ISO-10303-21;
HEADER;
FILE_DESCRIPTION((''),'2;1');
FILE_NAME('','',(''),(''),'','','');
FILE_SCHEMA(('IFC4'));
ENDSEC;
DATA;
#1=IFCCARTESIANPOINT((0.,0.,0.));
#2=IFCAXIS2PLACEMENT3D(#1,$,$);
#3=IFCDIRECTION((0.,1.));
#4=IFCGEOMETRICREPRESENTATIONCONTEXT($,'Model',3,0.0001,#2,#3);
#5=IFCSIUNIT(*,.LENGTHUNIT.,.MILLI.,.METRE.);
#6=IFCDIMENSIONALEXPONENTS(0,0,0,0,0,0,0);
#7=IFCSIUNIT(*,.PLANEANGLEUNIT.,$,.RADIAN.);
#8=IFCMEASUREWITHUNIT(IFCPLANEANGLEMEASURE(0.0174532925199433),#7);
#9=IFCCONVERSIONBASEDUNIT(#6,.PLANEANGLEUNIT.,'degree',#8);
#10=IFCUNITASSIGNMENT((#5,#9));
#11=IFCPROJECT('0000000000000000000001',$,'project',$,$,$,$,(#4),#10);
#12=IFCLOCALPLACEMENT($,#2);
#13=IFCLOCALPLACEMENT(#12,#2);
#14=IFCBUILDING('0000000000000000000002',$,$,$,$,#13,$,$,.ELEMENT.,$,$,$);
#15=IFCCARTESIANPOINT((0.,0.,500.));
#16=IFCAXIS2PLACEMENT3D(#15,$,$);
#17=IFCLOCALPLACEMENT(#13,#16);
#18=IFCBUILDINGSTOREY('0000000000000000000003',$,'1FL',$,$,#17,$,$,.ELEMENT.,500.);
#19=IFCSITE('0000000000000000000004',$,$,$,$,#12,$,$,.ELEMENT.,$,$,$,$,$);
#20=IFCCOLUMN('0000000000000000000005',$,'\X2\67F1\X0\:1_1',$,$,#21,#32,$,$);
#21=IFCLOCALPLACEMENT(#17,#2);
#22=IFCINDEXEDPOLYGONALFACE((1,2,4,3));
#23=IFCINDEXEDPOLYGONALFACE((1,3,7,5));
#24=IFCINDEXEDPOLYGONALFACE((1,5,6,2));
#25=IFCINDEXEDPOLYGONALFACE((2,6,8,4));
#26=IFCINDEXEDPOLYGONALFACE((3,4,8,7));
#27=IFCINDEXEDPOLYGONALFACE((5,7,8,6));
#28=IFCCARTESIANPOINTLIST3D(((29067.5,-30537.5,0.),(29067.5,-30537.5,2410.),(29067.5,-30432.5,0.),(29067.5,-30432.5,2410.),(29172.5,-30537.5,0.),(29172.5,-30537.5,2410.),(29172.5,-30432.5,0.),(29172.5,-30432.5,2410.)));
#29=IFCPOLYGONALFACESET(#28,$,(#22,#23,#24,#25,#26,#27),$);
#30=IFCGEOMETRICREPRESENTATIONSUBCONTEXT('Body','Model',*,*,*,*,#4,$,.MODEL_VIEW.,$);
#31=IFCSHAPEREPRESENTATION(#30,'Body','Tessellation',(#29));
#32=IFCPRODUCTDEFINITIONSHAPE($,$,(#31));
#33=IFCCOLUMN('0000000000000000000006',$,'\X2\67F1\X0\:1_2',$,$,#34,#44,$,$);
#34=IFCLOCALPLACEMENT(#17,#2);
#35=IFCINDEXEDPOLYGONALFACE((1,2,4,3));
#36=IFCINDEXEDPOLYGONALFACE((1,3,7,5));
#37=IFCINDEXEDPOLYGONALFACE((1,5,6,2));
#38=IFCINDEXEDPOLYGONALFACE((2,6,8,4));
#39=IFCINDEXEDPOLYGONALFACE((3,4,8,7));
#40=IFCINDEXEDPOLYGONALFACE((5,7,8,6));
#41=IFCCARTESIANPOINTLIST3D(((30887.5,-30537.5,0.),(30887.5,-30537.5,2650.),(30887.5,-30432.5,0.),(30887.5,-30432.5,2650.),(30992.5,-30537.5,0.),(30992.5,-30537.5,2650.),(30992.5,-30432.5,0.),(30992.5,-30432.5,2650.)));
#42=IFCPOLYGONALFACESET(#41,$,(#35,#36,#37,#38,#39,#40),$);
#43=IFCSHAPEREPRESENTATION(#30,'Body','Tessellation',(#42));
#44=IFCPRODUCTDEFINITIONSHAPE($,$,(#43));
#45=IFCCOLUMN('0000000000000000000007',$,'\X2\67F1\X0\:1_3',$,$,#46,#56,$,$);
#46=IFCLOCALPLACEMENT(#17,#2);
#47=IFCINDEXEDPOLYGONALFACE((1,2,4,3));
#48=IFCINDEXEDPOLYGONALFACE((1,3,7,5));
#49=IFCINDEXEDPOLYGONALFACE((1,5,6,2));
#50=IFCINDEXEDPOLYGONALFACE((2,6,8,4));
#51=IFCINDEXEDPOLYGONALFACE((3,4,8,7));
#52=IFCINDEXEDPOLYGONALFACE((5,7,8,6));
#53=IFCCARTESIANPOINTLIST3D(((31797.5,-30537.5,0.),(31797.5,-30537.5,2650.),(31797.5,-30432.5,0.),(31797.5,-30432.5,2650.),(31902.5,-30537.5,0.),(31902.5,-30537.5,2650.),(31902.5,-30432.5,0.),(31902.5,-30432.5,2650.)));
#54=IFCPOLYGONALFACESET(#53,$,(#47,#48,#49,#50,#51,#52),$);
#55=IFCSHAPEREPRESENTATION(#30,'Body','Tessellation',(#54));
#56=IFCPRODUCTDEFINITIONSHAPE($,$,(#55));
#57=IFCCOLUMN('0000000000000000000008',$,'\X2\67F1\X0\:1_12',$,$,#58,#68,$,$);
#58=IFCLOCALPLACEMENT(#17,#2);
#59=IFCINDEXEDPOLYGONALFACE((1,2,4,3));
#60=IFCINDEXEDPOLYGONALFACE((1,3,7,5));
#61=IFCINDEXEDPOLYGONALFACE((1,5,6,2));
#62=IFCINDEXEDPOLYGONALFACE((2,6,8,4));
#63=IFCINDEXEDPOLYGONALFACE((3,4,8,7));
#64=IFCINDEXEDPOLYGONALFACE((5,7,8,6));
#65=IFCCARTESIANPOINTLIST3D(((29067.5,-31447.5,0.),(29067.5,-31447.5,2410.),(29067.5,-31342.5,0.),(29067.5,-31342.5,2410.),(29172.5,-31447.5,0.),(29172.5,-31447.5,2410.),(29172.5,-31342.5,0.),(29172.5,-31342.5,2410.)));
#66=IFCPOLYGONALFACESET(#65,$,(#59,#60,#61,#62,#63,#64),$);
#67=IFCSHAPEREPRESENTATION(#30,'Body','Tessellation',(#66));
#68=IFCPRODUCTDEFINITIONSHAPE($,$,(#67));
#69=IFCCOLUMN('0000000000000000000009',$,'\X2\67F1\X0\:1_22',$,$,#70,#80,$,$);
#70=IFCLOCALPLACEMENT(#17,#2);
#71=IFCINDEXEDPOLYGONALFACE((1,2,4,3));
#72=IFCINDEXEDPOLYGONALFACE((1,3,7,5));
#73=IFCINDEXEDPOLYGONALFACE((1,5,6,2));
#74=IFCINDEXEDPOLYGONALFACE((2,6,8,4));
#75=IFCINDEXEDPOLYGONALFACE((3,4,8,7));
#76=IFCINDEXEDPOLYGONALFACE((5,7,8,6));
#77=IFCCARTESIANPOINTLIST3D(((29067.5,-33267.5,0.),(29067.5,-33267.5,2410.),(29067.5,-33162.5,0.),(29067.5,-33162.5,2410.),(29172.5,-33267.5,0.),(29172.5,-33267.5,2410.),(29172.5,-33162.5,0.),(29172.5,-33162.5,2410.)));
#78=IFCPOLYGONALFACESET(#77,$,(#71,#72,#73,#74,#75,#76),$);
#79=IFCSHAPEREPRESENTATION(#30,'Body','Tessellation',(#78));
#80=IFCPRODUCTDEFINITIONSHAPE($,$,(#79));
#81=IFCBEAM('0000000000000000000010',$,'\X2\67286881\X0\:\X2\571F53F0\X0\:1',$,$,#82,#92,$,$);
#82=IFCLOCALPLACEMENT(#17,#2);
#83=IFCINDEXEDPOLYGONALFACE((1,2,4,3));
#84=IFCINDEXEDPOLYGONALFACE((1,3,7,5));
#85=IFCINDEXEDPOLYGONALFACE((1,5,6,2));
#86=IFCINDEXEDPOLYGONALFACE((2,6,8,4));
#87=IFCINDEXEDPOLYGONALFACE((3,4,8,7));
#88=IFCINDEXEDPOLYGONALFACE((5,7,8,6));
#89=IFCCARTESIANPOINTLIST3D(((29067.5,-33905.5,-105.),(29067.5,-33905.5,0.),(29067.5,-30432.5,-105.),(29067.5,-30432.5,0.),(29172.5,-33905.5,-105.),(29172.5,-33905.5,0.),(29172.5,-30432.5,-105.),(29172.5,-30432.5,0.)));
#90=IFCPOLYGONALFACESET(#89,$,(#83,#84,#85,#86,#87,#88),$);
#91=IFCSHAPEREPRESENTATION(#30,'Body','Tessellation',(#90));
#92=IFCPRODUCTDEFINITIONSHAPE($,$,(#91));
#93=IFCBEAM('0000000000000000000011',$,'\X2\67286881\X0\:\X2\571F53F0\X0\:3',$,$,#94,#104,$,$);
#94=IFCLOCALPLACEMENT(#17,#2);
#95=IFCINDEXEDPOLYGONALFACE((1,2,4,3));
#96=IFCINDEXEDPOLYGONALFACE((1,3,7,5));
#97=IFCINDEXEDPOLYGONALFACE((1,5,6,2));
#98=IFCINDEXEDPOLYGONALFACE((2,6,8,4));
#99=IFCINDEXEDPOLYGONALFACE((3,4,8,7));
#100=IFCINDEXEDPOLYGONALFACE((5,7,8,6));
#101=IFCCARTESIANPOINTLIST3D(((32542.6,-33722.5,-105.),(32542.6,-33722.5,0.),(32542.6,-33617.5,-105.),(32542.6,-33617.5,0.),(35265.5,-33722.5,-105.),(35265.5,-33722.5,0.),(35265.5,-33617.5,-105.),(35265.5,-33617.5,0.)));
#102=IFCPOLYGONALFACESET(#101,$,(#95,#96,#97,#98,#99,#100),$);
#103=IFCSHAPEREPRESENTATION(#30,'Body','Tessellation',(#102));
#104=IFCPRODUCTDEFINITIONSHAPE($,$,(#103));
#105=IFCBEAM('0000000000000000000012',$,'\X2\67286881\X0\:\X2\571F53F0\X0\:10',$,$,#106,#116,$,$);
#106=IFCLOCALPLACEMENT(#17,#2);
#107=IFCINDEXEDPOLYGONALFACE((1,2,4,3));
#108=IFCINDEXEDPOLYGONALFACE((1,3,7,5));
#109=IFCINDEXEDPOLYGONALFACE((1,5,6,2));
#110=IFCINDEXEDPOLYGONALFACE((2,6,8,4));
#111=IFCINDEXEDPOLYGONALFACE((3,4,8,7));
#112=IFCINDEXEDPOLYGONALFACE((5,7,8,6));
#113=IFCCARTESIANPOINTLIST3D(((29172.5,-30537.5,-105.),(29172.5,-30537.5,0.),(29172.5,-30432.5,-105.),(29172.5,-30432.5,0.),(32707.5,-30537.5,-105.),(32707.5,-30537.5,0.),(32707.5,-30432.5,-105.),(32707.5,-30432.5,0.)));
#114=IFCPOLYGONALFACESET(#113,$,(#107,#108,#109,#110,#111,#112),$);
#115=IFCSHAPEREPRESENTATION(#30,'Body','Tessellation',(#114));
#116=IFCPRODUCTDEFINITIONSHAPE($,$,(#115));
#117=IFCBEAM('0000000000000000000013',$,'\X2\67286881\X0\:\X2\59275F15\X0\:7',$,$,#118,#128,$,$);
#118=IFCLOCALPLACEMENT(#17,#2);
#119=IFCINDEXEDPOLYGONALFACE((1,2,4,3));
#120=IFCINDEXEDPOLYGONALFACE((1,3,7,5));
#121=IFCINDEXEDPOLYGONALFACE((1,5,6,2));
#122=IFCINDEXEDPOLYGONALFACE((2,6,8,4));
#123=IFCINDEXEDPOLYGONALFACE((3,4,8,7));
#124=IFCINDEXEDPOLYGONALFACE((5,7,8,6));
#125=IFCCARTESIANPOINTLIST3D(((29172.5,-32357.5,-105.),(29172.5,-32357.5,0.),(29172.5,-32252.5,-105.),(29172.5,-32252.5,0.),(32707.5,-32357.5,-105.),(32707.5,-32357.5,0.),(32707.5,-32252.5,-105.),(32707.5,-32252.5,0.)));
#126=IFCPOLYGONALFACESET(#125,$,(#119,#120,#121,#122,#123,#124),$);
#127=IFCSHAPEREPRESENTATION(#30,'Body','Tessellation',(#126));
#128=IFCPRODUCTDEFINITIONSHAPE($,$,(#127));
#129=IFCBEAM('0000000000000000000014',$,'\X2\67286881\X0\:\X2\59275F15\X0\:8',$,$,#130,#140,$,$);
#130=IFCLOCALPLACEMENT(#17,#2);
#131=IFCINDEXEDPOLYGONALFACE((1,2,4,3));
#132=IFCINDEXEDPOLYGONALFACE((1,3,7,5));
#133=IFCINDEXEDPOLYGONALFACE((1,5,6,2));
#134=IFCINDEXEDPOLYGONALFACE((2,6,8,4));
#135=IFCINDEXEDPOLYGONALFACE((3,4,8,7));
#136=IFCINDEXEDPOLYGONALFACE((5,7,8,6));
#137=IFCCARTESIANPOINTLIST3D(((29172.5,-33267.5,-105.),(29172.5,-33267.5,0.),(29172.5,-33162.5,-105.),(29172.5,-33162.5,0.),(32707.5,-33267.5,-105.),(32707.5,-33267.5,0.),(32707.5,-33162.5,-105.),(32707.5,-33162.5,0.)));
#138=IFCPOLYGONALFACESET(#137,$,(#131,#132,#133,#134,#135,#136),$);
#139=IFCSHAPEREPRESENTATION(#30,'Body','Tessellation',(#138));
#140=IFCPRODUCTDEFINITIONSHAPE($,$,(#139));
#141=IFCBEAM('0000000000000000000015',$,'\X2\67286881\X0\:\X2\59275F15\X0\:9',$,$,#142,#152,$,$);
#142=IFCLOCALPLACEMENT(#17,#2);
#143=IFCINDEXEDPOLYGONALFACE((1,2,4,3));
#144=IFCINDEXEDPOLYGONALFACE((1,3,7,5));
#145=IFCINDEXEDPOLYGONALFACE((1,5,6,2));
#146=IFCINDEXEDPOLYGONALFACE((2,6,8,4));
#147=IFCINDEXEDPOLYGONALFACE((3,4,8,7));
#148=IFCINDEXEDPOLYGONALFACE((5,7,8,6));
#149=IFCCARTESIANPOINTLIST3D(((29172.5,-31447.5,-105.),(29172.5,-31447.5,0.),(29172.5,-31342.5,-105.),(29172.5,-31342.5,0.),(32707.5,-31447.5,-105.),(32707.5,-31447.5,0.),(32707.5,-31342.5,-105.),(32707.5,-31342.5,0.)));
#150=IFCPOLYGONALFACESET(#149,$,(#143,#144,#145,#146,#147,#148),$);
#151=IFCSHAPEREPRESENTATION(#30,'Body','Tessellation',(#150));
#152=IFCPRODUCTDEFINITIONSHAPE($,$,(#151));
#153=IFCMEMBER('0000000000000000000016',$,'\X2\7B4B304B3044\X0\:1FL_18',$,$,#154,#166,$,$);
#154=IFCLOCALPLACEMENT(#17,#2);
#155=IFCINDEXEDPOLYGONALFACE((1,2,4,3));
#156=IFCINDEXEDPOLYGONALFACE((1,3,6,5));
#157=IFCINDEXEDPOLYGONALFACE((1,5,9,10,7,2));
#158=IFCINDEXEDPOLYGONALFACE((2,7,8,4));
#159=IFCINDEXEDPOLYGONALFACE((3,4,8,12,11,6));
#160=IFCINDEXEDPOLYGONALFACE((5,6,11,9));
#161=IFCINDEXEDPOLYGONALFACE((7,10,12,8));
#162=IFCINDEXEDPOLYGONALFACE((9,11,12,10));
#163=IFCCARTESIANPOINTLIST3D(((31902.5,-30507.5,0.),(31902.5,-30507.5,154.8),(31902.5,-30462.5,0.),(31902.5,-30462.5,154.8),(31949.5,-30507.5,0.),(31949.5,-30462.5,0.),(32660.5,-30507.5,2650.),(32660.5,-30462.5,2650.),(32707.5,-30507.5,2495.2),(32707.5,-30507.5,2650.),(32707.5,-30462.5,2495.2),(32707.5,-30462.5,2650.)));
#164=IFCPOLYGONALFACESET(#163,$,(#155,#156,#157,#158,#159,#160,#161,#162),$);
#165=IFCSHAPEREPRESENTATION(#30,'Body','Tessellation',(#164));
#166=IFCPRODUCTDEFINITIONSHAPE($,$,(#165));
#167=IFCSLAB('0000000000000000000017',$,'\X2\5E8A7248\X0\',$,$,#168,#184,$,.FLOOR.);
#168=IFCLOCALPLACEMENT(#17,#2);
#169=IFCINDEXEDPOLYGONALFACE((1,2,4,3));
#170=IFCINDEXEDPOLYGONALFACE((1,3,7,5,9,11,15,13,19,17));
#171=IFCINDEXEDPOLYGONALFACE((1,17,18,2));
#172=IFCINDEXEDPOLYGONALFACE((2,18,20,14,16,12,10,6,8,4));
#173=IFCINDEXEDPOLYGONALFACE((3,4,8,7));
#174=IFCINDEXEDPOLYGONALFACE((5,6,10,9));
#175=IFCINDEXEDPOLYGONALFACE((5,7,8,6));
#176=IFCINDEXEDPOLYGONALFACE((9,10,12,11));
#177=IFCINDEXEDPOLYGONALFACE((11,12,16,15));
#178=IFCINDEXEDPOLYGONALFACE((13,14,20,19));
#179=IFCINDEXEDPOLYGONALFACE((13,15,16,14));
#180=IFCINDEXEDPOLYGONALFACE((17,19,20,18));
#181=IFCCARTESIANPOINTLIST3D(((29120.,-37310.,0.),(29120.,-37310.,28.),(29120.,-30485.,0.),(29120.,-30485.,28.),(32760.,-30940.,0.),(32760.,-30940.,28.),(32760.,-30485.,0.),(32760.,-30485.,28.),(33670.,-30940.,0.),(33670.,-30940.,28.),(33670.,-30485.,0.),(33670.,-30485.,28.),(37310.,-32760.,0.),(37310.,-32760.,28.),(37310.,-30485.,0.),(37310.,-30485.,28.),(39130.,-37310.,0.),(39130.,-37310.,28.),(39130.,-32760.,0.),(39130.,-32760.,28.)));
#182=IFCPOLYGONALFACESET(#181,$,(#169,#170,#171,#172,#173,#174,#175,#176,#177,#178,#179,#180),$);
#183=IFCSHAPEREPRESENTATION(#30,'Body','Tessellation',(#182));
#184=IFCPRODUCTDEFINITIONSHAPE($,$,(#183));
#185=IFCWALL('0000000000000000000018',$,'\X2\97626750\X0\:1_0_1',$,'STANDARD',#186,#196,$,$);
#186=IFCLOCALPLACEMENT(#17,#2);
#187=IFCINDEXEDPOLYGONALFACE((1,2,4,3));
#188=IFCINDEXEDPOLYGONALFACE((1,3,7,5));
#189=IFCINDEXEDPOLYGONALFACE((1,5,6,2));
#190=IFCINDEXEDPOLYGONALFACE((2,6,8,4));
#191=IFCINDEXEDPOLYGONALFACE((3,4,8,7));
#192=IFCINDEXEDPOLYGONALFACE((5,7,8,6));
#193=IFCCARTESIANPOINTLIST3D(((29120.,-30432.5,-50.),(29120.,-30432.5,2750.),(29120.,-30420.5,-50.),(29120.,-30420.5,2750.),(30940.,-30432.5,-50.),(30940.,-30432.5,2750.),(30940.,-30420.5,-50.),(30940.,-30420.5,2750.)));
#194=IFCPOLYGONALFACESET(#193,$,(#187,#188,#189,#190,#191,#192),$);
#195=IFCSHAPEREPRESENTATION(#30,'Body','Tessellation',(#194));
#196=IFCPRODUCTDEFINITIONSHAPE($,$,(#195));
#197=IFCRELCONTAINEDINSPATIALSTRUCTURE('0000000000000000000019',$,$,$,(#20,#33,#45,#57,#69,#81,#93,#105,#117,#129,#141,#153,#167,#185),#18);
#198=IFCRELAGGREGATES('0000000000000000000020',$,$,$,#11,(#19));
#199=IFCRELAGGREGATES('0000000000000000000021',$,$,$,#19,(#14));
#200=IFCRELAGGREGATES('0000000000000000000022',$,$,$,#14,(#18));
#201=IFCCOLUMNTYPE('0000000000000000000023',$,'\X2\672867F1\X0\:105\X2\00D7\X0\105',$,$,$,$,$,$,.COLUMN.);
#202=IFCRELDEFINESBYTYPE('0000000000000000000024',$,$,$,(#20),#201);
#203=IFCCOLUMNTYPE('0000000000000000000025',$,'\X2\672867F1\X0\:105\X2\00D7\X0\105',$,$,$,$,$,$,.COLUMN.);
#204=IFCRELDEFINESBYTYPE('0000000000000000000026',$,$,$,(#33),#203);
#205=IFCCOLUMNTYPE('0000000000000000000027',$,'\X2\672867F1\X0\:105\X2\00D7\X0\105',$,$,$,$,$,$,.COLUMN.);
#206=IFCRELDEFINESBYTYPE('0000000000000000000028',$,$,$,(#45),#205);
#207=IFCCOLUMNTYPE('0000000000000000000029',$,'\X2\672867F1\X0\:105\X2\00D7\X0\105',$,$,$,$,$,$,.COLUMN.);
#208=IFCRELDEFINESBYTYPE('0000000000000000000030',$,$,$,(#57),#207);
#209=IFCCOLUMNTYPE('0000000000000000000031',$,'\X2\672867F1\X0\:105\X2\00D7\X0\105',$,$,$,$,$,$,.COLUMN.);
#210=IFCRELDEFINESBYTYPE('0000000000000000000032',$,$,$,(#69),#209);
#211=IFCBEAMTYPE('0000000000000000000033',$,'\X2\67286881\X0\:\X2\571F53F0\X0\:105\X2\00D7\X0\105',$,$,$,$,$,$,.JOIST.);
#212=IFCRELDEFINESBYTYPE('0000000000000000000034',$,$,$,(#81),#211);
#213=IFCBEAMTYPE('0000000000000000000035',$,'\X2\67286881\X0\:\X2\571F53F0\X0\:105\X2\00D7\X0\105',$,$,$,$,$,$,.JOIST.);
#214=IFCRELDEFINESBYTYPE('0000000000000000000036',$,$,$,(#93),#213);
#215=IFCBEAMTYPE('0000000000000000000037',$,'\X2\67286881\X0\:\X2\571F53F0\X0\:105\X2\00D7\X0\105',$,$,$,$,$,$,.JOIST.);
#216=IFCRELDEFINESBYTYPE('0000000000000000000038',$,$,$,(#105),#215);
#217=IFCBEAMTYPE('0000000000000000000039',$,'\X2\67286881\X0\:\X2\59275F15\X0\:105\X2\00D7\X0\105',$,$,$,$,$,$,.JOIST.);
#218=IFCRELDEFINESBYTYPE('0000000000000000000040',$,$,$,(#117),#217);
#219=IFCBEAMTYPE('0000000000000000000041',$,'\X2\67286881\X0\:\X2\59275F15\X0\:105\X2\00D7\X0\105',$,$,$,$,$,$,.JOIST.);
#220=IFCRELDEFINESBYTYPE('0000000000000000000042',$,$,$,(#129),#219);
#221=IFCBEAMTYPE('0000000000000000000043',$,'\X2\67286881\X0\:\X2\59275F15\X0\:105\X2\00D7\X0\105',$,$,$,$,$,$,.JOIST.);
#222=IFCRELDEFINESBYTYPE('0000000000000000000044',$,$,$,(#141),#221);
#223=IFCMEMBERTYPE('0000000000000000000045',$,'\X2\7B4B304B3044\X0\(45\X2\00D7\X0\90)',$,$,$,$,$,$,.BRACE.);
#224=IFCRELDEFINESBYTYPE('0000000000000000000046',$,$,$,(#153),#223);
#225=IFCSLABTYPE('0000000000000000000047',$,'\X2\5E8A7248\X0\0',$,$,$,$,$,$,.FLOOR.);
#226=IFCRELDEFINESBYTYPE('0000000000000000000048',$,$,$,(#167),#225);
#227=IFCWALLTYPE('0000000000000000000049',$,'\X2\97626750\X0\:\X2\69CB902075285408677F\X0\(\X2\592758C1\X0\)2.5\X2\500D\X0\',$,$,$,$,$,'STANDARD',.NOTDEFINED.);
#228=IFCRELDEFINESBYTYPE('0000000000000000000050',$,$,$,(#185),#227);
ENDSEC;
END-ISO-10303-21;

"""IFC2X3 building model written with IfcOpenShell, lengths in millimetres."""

from ifc_helpers import new_model, entity, si_unit, converted_unit, direction, frame, origin, origin_with_axes, origin_2d, place, context, subcontext, project, spatial, polyline, rectangle, outline, extrude, type_object, element, save


model = new_model("IFC2X3")

# Units and contexts
model_context = context("Model", 3, precision=0.0001, world=origin(), true_north=direction((0.0, 1.0)))
body_context = subcontext(model_context, "Body", "Model", "MODEL_VIEW")
ifc_project = project(units=[si_unit("LENGTHUNIT", "METRE", prefix="MILLI"), converted_unit("PLANEANGLEUNIT", "degree", entity("IfcPlaneAngleMeasure", 0.0174532925199433), si_unit("PLANEANGLEUNIT", "RADIAN"), dimensions=[0, 0, 0, 0, 0, 0, 0])], contexts=[model_context])

# Site, building, storey
site_placement = place(None, origin())
site = spatial("IfcSite", under=ifc_project, at=site_placement, CompositionType="ELEMENT")
building_placement = place(site_placement, origin())
building = spatial("IfcBuilding", under=site, at=building_placement, CompositionType="ELEMENT")
storey_placement = place(building_placement, frame((0.0, 0.0, 500.0)))
storey = spatial("IfcBuildingStorey", under=building, at=storey_placement, Name="1FL", CompositionType="ELEMENT", Elevation=500.0)

# Columns
column_type_1 = type_object("IfcColumnType", Name="木柱:105×105", PredefinedType="COLUMN")
column_1_placement = place(storey_placement, frame((29120.0, -30485.0, 0.0)))
element("IfcColumn", 1, at=column_1_placement, inside=storey, type_object=column_type_1, Name="柱:1_1", context=body_context, shape_type="SweptSolid", body=[
    extrude(rectangle(XDim=105.0, YDim=105.0, at=origin_2d()), origin_with_axes(), (0.0, 0.0, 1.0), 2410.0),
])
column_type_2 = type_object("IfcColumnType", Name="木柱:105×105", PredefinedType="COLUMN")
column_2_placement = place(storey_placement, frame((30940.0, -30485.0, 0.0)))
element("IfcColumn", 2, at=column_2_placement, inside=storey, type_object=column_type_2, Name="柱:1_2", context=body_context, shape_type="SweptSolid", body=[
    extrude(rectangle(XDim=105.0, YDim=105.0, at=origin_2d()), origin_with_axes(), (0.0, 0.0, 1.0), 2650.0),
])
column_type_3 = type_object("IfcColumnType", Name="木柱:105×105", PredefinedType="COLUMN")
column_3_placement = place(storey_placement, frame((31850.0, -30485.0, 0.0)))
element("IfcColumn", 3, at=column_3_placement, inside=storey, type_object=column_type_3, Name="柱:1_3", context=body_context, shape_type="SweptSolid", body=[
    extrude(rectangle(XDim=105.0, YDim=105.0, at=origin_2d()), origin_with_axes(), (0.0, 0.0, 1.0), 2650.0),
])
column_type_4 = type_object("IfcColumnType", Name="木柱:105×105", PredefinedType="COLUMN")
column_4_placement = place(storey_placement, frame((29120.0, -31395.0, 0.0)))
element("IfcColumn", 4, at=column_4_placement, inside=storey, type_object=column_type_4, Name="柱:1_12", context=body_context, shape_type="SweptSolid", body=[
    extrude(rectangle(XDim=105.0, YDim=105.0, at=origin_2d()), origin_with_axes(), (0.0, 0.0, 1.0), 2410.0),
])
column_type_5 = type_object("IfcColumnType", Name="木柱:105×105", PredefinedType="COLUMN")
column_5_placement = place(storey_placement, frame((29120.0, -33215.0, 0.0)))
element("IfcColumn", 5, at=column_5_placement, inside=storey, type_object=column_type_5, Name="柱:1_22", context=body_context, shape_type="SweptSolid", body=[
    extrude(rectangle(XDim=105.0, YDim=105.0, at=origin_2d()), origin_with_axes(), (0.0, 0.0, 1.0), 2410.0),
])

# Beams
beam_type_1 = type_object("IfcBeamType", Name="木梁:土台:105×105", PredefinedType="JOIST")
beam_1_placement = place(storey_placement, frame((29120.0, -30432.5, -52.5), z_axis=(0.0, -1.0, 0.0), x_axis=(1.0, 0.0, 0.0)))
element("IfcBeam", 6, at=beam_1_placement, inside=storey, type_object=beam_type_1, Name="木梁:土台:1", context=body_context, shape_type="SweptSolid", body=[
    extrude(rectangle(XDim=105.0, YDim=105.0, at=origin_2d()), origin_with_axes(), (0.0, 0.0, 1.0), 3473.0),
])
beam_type_2 = type_object("IfcBeamType", Name="木梁:土台:105×105", PredefinedType="JOIST")
beam_2_placement = place(storey_placement, frame((32542.6, -33670.0, -52.5), z_axis=(1.0, 0.0, 0.0), x_axis=(0.0, 1.0, 0.0)))
element("IfcBeam", 7, at=beam_2_placement, inside=storey, type_object=beam_type_2, Name="木梁:土台:3", context=body_context, shape_type="SweptSolid", body=[
    extrude(rectangle(XDim=105.0, YDim=105.0, at=origin_2d()), origin_with_axes(), (0.0, 0.0, 1.0), 2722.9),
])
beam_type_3 = type_object("IfcBeamType", Name="木梁:土台:105×105", PredefinedType="JOIST")
beam_3_placement = place(storey_placement, frame((29172.5, -30485.0, -52.5), z_axis=(1.0, 0.0, 0.0), x_axis=(0.0, 1.0, 0.0)))
element("IfcBeam", 8, at=beam_3_placement, inside=storey, type_object=beam_type_3, Name="木梁:土台:10", context=body_context, shape_type="SweptSolid", body=[
    extrude(rectangle(XDim=105.0, YDim=105.0, at=origin_2d()), origin_with_axes(), (0.0, 0.0, 1.0), 3535.0),
])
beam_type_4 = type_object("IfcBeamType", Name="木梁:大引:105×105", PredefinedType="JOIST")
beam_4_placement = place(storey_placement, frame((29172.5, -32305.0, -52.5), z_axis=(1.0, 0.0, 0.0), x_axis=(0.0, 1.0, 0.0)))
element("IfcBeam", 9, at=beam_4_placement, inside=storey, type_object=beam_type_4, Name="木梁:大引:7", context=body_context, shape_type="SweptSolid", body=[
    extrude(rectangle(XDim=105.0, YDim=105.0, at=origin_2d()), origin_with_axes(), (0.0, 0.0, 1.0), 3535.0),
])
beam_type_5 = type_object("IfcBeamType", Name="木梁:大引:105×105", PredefinedType="JOIST")
beam_5_placement = place(storey_placement, frame((29172.5, -33215.0, -52.5), z_axis=(1.0, 0.0, 0.0), x_axis=(0.0, 1.0, 0.0)))
element("IfcBeam", 10, at=beam_5_placement, inside=storey, type_object=beam_type_5, Name="木梁:大引:8", context=body_context, shape_type="SweptSolid", body=[
    extrude(rectangle(XDim=105.0, YDim=105.0, at=origin_2d()), origin_with_axes(), (0.0, 0.0, 1.0), 3535.0),
])
beam_type_6 = type_object("IfcBeamType", Name="木梁:大引:105×105", PredefinedType="JOIST")
beam_6_placement = place(storey_placement, frame((29172.5, -31395.0, -52.5), z_axis=(1.0, 0.0, 0.0), x_axis=(0.0, 1.0, 0.0)))
element("IfcBeam", 11, at=beam_6_placement, inside=storey, type_object=beam_type_6, Name="木梁:大引:9", context=body_context, shape_type="SweptSolid", body=[
    extrude(rectangle(XDim=105.0, YDim=105.0, at=origin_2d()), origin_with_axes(), (0.0, 0.0, 1.0), 3535.0),
])

# Member
member_type = type_object("IfcMemberType", Name="筋かい(45×90)", PredefinedType="BRACE")
member_placement = place(storey_placement, frame((31902.5, -30485.0, 0.0), z_axis=(0.290659, 0.0, 0.956827), x_axis=(-0.956827, 0.0, 0.290659)))
element("IfcMember", 12, at=member_placement, inside=storey, type_object=member_type, Name="筋かい:1FL_18", context=body_context, shape_type="SweptSolid", body=[
    extrude(outline(polyline([(0.0, 0.0), (13.7, -45.0), (2621.4, -45.0), (2769.6, 0.0), (2755.9, 45.0), (148.1, 45.0), (0.0, 0.0)])), frame((0.0, -22.5, 0.0), z_axis=(0.0, 1.0, 0.0), x_axis=(0.0, 0.0, 1.0)), (0.0, 0.0, 1.0), 45.0),
])

# Slab
slab_type = type_object("IfcSlabType", Name="床版0", PredefinedType="FLOOR")
slab_placement = place(storey_placement, origin_with_axes())
element("IfcSlab", 13, at=slab_placement, inside=storey, type_object=slab_type, Name="床版", PredefinedType="FLOOR", context=body_context, shape_type="SweptSolid", body=[
    extrude(outline(polyline([(37310.0, -30485.0, 0.0), (33670.0, -30485.0, 0.0), (33670.0, -30940.0, 0.0), (32760.0, -30940.0, 0.0), (32760.0, -30485.0, 0.0), (29120.0, -30485.0, 0.0), (29120.0, -37310.0, 0.0), (39130.0, -37310.0, 0.0), (39130.0, -32760.0, 0.0), (37310.0, -32760.0, 0.0), (37310.0, -30485.0, 0.0)])), origin_with_axes(), (0.0, 0.0, 1.0), 28.0),
])

# Wall
wall_type_1 = type_object("IfcWallType", Name="面材:構造用合板(大壁)2.5倍", ElementType="STANDARD", PredefinedType="NOTDEFINED")
wall_1_placement = place(storey_placement, frame((30030.0, -30420.5, -50.0), z_axis=(0.0, -1.0, 0.0), x_axis=(1.0, 0.0, 0.0)))
element("IfcWall", 14, at=wall_1_placement, inside=storey, type_object=wall_type_1, Name="面材:1_0_1", ObjectType="STANDARD", context=body_context, shape_type="SweptSolid", body=[
    extrude(outline(polyline([(910.0, 0.0, 0.0), (-910.0, 0.0, 0.0), (-910.0, 2800.0, 0.0), (910.0, 2800.0, 0.0), (910.0, 0.0, 0.0)])), origin_with_axes(), (0.0, 0.0, 1.0), 12.0),
])

save(model, "model.ifc")
